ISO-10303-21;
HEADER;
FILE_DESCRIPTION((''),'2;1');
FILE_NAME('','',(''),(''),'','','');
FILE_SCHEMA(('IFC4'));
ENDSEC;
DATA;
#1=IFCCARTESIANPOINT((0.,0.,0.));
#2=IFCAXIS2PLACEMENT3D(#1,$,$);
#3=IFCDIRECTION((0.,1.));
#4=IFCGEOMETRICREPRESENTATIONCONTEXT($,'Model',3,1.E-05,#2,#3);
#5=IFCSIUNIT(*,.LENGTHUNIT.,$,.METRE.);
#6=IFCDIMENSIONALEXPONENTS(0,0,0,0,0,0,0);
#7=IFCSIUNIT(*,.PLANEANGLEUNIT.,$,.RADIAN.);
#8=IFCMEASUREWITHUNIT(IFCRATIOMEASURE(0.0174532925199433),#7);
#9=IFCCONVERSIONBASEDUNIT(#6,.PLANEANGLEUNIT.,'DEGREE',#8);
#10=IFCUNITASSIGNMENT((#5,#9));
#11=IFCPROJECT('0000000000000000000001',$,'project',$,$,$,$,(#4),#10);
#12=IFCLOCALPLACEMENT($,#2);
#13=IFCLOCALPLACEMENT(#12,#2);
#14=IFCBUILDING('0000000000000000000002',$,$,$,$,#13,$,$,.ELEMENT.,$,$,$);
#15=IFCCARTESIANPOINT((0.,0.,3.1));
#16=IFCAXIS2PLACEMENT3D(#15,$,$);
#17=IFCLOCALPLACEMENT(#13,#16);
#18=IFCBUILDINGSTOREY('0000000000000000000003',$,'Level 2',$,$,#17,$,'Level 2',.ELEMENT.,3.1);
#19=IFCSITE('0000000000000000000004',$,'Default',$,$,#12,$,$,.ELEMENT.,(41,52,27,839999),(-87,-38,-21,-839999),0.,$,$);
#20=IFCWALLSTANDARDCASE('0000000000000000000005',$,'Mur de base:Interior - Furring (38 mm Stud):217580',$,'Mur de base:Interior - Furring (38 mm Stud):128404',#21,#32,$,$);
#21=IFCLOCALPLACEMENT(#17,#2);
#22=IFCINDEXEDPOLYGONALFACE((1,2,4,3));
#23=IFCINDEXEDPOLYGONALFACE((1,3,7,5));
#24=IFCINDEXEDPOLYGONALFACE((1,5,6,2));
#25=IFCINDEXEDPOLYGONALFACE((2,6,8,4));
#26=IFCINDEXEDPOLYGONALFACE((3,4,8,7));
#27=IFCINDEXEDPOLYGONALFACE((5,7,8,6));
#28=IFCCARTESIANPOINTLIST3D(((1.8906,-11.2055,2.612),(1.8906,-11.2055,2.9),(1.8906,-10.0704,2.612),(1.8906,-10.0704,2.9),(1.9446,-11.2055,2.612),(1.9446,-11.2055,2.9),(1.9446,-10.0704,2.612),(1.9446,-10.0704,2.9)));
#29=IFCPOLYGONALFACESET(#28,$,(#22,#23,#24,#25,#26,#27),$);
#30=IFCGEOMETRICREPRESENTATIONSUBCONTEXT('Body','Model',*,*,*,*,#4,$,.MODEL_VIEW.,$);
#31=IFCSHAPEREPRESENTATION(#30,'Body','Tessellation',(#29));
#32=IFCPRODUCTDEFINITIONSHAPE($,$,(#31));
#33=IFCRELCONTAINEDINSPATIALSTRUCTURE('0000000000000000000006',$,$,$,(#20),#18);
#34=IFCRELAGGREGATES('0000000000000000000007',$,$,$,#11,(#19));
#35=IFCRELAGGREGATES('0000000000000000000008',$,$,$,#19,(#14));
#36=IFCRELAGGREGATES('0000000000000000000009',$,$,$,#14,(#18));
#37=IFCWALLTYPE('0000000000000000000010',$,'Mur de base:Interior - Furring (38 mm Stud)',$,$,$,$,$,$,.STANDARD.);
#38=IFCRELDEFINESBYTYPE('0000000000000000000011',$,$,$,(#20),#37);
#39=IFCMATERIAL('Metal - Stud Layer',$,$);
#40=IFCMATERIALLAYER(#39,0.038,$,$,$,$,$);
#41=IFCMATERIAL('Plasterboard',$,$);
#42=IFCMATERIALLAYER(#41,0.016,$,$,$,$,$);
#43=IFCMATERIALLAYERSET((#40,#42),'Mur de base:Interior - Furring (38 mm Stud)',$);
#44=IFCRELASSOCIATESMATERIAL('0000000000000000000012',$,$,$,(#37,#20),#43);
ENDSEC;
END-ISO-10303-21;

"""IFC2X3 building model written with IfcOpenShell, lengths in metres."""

from ifc_helpers import new_model, entity, si_unit, converted_unit, direction, frame, frame_2d, origin, place, context, subcontext, project, spatial, rectangle, extrude, material, layer, layer_set, layer_usage, type_object, element, save


model = new_model("IFC2X3")

# Units and contexts
model_context = context("Model", 3, precision=1e-05, world=origin(), true_north=direction((0.0, 1.0)))
body_context = subcontext(model_context, "Body", "Model", "MODEL_VIEW")
ifc_project = project(units=[si_unit("LENGTHUNIT", "METRE"), converted_unit("PLANEANGLEUNIT", "DEGREE", entity("IfcRatioMeasure", 0.0174532925199433), si_unit("PLANEANGLEUNIT", "RADIAN"), dimensions=[0, 0, 0, 0, 0, 0, 0])], contexts=[model_context])

# Site, building, storey
site_placement = place(None, origin())
site = spatial("IfcSite", under=ifc_project, at=site_placement, Name="Default", CompositionType="ELEMENT", RefLatitude=(41, 52, 27, 839999), RefLongitude=(-87, -38, -21, -839999), RefElevation=0.0)
building_placement = place(site_placement, origin())
building = spatial("IfcBuilding", under=site, at=building_placement, CompositionType="ELEMENT")
storey_placement = place(building_placement, frame((0.0, 0.0, 3.1)))
storey = spatial("IfcBuildingStorey", under=building, at=storey_placement, Name="Level 2", LongName="Level 2", CompositionType="ELEMENT", Elevation=3.1)

# Shared definitions
ifc_material_1 = material(Name="Plasterboard")
ifc_material_2 = material(Name="Metal - Stud Layer")

# Wall
ifc_layer_1 = layer(ifc_material_2, 0.038)
ifc_layer_2 = layer(ifc_material_1, 0.016)
ifc_layer_set_1 = layer_set([ifc_layer_1, ifc_layer_2], Name="Mur de base:Interior - Furring (38 mm Stud)")
wall_type_1 = type_object("IfcWallType", Name="Mur de base:Interior - Furring (38 mm Stud)", PredefinedType="STANDARD", material=ifc_layer_set_1)
ifc_layer_usage_1 = layer_usage(ifc_layer_set_1, "AXIS2", "NEGATIVE", 0.027)
wall_1_placement = place(storey_placement, frame((1.9176, -10.0704, 2.612), z_axis=(0.0, 0.0, 1.0), x_axis=(0.0, -1.0, 0.0)))
element("IfcWallStandardCase", 1, at=wall_1_placement, inside=storey, type_object=wall_type_1, material=ifc_layer_usage_1, Name="Mur de base:Interior - Furring (38 mm Stud):217580", ObjectType="Mur de base:Interior - Furring (38 mm Stud):128404", context=body_context, shape_type="SweptSolid", body=[
    extrude(rectangle(XDim=1.1351, YDim=0.054, at=frame_2d((0.5675, 0.0), x_axis=(-1.0, 0.0))), origin(), (0.0, 0.0, 1.0), 0.288),
])

save(model, "model.ifc")
